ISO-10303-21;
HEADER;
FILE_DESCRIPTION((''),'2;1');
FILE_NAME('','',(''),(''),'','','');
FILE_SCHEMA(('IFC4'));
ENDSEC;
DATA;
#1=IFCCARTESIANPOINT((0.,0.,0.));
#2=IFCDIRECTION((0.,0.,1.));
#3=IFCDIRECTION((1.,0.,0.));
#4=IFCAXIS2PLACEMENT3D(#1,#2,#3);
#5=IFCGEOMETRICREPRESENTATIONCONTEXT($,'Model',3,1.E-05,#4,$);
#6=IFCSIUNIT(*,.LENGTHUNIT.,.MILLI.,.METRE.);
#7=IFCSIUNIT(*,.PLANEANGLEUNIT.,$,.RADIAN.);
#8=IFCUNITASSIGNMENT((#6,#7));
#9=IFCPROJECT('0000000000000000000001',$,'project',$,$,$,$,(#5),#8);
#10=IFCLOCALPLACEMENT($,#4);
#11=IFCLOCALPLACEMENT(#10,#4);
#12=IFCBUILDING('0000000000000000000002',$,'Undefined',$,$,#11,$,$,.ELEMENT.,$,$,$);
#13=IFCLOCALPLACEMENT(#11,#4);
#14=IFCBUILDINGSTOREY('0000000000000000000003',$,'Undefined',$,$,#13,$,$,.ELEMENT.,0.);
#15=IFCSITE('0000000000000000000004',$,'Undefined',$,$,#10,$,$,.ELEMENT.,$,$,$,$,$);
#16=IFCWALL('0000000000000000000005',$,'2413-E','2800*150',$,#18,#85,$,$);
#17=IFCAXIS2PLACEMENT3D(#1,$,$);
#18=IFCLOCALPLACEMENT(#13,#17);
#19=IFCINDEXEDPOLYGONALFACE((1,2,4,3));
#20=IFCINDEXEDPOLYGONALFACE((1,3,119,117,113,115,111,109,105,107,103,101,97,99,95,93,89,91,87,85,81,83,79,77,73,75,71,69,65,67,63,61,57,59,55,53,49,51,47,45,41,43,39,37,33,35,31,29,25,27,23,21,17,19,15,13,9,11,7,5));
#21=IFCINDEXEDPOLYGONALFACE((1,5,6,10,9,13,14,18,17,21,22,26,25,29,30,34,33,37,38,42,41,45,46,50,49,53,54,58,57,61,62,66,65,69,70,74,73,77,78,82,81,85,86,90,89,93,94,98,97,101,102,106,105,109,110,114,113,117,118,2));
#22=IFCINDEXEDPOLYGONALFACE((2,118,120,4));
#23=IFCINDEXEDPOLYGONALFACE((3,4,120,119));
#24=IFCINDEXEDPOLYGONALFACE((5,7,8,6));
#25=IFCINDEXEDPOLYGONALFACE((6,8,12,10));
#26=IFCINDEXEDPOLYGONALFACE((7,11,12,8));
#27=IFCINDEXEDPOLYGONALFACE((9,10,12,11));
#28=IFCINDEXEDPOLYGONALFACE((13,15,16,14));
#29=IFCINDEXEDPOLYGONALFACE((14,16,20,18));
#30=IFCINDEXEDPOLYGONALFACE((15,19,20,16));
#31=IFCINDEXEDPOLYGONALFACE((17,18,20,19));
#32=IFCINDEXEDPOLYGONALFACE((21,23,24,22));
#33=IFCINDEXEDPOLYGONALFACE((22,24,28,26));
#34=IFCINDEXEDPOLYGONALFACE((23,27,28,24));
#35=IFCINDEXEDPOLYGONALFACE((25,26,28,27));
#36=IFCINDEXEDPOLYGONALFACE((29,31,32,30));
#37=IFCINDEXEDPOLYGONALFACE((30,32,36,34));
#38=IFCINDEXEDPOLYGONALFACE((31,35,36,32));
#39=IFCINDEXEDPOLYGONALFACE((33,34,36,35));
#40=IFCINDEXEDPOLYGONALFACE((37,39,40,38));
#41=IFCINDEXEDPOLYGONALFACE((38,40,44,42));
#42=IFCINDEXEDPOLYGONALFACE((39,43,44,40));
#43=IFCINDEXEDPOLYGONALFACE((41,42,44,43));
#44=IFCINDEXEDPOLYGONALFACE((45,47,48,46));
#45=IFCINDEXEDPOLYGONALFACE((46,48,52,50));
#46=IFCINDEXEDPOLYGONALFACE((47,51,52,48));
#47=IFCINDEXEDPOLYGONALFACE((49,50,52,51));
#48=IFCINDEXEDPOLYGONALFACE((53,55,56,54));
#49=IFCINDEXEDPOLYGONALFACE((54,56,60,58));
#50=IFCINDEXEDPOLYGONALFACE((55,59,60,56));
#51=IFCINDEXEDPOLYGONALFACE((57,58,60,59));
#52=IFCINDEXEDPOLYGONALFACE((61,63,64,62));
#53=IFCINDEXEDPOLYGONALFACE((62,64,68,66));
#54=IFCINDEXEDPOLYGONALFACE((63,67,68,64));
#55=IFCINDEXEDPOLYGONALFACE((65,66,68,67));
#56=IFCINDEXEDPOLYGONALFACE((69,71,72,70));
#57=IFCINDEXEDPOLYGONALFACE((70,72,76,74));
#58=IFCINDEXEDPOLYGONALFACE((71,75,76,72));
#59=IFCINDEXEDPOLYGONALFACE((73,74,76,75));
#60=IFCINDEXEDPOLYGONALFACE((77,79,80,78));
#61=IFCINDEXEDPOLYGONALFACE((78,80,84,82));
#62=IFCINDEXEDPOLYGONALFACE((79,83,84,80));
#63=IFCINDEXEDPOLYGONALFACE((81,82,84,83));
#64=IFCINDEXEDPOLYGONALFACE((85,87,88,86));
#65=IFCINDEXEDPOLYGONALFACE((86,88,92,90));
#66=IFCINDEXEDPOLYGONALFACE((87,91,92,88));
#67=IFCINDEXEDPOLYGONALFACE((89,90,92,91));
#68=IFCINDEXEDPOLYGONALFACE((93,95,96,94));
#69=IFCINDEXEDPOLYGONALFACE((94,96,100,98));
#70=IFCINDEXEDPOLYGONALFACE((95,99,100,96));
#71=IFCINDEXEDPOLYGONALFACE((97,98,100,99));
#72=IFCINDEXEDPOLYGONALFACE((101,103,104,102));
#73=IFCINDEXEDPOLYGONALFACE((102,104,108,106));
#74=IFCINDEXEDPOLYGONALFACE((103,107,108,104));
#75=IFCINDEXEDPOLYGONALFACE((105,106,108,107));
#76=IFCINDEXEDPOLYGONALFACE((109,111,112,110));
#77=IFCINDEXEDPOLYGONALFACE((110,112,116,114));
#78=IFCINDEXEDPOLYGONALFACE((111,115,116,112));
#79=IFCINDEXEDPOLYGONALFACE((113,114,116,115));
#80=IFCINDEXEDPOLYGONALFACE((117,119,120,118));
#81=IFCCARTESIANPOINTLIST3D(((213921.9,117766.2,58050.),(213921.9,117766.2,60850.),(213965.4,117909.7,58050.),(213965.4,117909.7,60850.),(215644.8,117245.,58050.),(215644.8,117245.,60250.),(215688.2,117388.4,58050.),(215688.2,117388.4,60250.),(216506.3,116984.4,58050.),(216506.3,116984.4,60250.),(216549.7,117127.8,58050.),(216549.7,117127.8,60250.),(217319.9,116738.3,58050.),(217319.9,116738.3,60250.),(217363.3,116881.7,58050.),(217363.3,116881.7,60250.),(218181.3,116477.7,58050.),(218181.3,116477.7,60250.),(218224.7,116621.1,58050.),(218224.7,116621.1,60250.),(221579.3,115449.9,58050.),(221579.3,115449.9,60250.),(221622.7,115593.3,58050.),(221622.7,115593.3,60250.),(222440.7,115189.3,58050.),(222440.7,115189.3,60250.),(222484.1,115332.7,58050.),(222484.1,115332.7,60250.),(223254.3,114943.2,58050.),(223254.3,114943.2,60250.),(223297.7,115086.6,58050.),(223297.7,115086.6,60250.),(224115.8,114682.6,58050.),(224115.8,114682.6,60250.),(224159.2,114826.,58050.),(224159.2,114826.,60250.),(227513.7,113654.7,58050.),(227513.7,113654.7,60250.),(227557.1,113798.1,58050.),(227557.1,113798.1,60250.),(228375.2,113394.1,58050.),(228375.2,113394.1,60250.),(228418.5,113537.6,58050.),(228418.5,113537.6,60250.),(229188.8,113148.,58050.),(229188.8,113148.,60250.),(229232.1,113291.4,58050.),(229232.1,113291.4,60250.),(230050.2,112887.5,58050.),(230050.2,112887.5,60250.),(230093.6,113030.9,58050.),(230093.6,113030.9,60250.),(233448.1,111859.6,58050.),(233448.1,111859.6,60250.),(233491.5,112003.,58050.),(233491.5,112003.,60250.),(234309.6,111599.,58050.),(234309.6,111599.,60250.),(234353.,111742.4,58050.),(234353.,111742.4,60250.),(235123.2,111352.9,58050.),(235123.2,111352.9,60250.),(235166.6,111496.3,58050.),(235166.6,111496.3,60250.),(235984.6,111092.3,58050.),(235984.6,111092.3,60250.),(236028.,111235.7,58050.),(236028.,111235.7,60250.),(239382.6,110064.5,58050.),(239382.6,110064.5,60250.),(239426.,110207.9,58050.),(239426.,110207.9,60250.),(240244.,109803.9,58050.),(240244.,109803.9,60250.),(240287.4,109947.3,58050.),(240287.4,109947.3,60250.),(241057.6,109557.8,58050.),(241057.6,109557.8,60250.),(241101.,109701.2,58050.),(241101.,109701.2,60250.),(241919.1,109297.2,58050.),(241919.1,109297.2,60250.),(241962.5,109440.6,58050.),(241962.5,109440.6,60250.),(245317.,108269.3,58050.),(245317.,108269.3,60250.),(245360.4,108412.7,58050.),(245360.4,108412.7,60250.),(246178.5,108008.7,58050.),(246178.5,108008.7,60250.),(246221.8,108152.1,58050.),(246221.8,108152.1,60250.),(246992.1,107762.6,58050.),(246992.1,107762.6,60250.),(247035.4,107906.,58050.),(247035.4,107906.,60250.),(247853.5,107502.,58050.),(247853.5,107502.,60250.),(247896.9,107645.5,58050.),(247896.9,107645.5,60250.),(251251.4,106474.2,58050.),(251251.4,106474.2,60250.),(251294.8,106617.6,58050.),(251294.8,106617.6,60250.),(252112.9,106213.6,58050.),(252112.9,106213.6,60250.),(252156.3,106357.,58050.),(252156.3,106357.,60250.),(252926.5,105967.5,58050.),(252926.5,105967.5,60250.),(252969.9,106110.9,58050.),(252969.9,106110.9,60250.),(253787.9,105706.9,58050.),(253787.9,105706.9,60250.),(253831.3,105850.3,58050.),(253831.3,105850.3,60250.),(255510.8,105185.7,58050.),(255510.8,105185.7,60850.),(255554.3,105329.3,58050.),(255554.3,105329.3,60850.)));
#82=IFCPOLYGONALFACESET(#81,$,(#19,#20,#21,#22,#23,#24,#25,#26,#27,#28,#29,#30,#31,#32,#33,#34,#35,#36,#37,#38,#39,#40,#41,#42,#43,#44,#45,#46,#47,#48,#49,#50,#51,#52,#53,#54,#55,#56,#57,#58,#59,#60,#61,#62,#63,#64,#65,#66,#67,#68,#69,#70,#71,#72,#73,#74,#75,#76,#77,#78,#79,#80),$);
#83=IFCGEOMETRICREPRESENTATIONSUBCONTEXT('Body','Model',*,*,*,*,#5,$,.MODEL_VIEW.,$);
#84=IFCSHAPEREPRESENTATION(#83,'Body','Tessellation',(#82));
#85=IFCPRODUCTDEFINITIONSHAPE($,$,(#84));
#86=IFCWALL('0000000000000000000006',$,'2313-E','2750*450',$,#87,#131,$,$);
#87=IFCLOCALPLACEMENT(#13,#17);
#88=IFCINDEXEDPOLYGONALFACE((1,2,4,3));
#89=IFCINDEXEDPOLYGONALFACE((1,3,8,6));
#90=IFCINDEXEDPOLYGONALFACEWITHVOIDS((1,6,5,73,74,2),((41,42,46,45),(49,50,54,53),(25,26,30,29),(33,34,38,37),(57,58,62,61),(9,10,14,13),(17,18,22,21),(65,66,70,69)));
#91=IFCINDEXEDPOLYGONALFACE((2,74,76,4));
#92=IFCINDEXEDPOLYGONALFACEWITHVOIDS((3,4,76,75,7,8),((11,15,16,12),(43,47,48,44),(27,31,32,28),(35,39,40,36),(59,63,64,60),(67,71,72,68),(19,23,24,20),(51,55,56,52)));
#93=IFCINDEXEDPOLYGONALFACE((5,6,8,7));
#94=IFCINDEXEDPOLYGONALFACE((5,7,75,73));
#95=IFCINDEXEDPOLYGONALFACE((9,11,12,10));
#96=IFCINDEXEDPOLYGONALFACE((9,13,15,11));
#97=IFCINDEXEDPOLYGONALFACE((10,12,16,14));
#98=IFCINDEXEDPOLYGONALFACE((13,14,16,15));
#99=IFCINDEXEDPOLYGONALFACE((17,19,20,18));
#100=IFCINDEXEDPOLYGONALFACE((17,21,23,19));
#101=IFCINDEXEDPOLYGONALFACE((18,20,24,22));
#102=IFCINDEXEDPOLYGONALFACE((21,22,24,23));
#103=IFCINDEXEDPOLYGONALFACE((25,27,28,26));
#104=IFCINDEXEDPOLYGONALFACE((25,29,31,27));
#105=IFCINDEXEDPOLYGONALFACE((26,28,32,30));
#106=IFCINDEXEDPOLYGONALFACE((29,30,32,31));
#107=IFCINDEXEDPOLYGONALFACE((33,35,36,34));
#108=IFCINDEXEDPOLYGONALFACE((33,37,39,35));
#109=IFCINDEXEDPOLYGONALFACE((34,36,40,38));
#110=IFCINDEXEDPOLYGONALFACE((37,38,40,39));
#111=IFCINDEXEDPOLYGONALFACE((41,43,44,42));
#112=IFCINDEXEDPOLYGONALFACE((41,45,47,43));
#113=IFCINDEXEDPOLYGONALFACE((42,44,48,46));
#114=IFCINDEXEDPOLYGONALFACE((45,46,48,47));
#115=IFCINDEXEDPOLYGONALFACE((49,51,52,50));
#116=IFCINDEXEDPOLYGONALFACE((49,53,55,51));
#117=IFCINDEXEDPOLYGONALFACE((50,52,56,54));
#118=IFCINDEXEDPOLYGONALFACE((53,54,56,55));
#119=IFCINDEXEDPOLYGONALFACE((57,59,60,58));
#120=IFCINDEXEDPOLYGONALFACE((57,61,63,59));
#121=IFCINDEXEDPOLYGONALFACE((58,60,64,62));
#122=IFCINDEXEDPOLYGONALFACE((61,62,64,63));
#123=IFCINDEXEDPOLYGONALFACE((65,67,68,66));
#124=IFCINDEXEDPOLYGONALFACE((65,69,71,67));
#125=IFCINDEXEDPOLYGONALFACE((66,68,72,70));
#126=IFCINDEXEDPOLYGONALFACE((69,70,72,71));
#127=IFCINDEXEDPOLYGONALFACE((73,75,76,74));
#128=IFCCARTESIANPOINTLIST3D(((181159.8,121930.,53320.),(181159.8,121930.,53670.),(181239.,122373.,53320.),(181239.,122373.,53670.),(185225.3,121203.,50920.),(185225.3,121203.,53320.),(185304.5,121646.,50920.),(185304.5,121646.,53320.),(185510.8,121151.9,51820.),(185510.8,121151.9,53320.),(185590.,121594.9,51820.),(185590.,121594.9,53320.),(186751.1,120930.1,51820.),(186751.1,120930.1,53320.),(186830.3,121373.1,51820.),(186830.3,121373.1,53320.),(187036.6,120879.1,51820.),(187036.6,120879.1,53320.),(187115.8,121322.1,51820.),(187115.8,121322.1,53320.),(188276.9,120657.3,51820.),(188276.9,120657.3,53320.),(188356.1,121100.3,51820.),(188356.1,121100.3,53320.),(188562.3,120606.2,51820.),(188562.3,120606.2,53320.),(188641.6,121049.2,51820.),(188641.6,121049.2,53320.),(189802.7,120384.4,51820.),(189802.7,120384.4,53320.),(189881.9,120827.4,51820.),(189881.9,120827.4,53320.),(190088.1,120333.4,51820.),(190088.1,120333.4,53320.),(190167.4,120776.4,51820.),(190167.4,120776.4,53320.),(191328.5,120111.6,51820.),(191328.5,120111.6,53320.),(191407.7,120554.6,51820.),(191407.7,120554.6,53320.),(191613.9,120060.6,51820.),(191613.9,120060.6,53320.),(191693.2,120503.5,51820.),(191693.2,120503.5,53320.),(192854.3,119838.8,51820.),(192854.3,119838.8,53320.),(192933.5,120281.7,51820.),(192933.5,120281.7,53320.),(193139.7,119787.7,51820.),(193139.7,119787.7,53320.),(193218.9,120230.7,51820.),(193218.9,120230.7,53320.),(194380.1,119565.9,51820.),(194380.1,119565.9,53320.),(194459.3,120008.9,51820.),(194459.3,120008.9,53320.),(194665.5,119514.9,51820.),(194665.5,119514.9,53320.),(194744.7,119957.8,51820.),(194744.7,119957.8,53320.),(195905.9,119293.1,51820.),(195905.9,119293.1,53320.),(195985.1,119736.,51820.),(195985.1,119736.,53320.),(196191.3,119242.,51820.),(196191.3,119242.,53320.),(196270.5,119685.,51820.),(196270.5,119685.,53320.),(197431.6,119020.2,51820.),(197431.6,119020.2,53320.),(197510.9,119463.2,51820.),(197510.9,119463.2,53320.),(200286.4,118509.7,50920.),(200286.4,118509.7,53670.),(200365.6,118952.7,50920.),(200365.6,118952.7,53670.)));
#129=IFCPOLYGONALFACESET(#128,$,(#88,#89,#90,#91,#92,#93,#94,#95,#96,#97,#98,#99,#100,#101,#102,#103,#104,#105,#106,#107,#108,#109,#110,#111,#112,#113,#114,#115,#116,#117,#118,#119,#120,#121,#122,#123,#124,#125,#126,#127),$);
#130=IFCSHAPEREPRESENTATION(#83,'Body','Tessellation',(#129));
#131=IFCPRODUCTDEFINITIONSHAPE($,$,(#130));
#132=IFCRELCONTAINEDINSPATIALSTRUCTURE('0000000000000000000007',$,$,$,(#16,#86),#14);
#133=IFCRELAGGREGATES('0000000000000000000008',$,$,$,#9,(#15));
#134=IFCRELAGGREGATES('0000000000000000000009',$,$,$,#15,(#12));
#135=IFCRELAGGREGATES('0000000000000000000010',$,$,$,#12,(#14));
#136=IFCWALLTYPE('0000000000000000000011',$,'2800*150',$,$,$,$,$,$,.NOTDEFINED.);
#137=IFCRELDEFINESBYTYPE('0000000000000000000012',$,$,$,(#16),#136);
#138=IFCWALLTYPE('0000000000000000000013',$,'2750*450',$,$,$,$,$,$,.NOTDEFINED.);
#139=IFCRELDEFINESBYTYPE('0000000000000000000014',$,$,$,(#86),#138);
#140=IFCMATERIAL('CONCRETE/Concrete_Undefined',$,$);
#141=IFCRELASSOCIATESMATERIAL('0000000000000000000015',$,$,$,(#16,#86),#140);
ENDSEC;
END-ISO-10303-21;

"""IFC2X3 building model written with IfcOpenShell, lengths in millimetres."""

from ifc_helpers import new_model, si_unit, frame, frame_2d, origin_with_axes, place, context, subcontext, project, spatial, rectangle, extrude, boolean, material, type_object, element, save


model = new_model("IFC2X3")

# Units and contexts
model_context = context("Model", 3, precision=1e-05, world=origin_with_axes())
body_context = subcontext(model_context, "Body", "Model", "MODEL_VIEW")
ifc_project = project(units=[si_unit("LENGTHUNIT", "METRE", prefix="MILLI"), si_unit("PLANEANGLEUNIT", "RADIAN")], contexts=[model_context])

# Site, building, storey
site_placement = place(None, origin_with_axes())
site = spatial("IfcSite", under=ifc_project, at=site_placement, Name="Undefined", CompositionType="ELEMENT")
building_placement = place(site_placement, origin_with_axes())
building = spatial("IfcBuilding", under=site, at=building_placement, Name="Undefined", CompositionType="ELEMENT")
storey_placement = place(building_placement, origin_with_axes())
storey = spatial("IfcBuildingStorey", under=building, at=storey_placement, Name="Undefined", CompositionType="ELEMENT", Elevation=0.0)

# Shared definitions
ifc_material_1 = material(Name="CONCRETE/Concrete_Undefined")

# Walls
wall_type_1 = type_object("IfcWallType", Name="2800*150", PredefinedType="NOTDEFINED")
wall_1_placement = place(storey_placement, frame((213943.7, 117838.0, 58050.0), z_axis=(0.0, 0.0, 1.0), x_axis=(0.957167, -0.289538, 0.0)))
solid_1 = boolean("DIFFERENCE", boolean("DIFFERENCE", boolean("DIFFERENCE", boolean("DIFFERENCE", boolean("DIFFERENCE", boolean("DIFFERENCE", boolean("DIFFERENCE", boolean("DIFFERENCE", extrude(rectangle(XDim=43450.0, YDim=150.0, at=frame_2d((0.0, 21725.0), x_axis=(0.0, -1.0))), frame((0.0, 0.0, 0.0), z_axis=(0.0, 0.0, 1.0), x_axis=(0.0, -1.0, 0.0)), (0.0, 0.0, 1.0), 2800.0), extrude(rectangle(XDim=900.0, YDim=150.0, at=frame_2d((0.0, 450.0), x_axis=(0.0, -1.0))), frame((39000.0, -0.2, 0.0), z_axis=(0.0, 0.0, 1.0), x_axis=(-0.000003, -1.0, 0.0)), (0.0, 0.0, 1.0), 2200.0)), extrude(rectangle(XDim=900.0, YDim=150.0, at=frame_2d((0.0, 450.0), x_axis=(0.0, -1.0))), frame((40750.0, -0.2, 0.0), z_axis=(0.0, 0.0, 1.0), x_axis=(-0.000003, -1.0, 0.0)), (0.0, 0.0, 1.0), 2200.0)), extrude(rectangle(XDim=900.0, YDim=150.0, at=frame_2d((0.0, 450.0), x_axis=(0.0, -1.0))), frame((32800.0, -0.2, 0.0), z_axis=(0.0, 0.0, 1.0), x_axis=(-0.000003, -1.0, 0.0)), (0.0, 0.0, 1.0), 2200.0)), extrude(rectangle(XDim=900.0, YDim=150.0, at=frame_2d((0.0, 450.0), x_axis=(0.0, -1.0))), frame((34550.0, -0.2, 0.0), z_axis=(0.0, 0.0, 1.0), x_axis=(-0.000003, -1.0, 0.0)), (0.0, 0.0, 1.0), 2200.0)), extrude(rectangle(XDim=900.0, YDim=150.0, at=frame_2d((0.0, 450.0), x_axis=(0.0, -1.0))), frame((26600.0, -0.2, 0.0), z_axis=(0.0, 0.0, 1.0), x_axis=(-0.000003, -1.0, 0.0)), (0.0, 0.0, 1.0), 2200.0)), extrude(rectangle(XDim=900.0, YDim=150.0, at=frame_2d((0.0, 450.0), x_axis=(0.0, -1.0))), frame((28350.0, -0.2, 0.0), z_axis=(0.0, 0.0, 1.0), x_axis=(-0.000003, -1.0, 0.0)), (0.0, 0.0, 1.0), 2200.0)), extrude(rectangle(XDim=900.0, YDim=150.0, at=frame_2d((0.0, 450.0), x_axis=(0.0, -1.0))), frame((20400.0, -0.2, 0.0), z_axis=(0.0, 0.0, 1.0), x_axis=(-0.000003, -1.0, 0.0)), (0.0, 0.0, 1.0), 2200.0)), extrude(rectangle(XDim=900.0, YDim=150.0, at=frame_2d((0.0, 450.0), x_axis=(0.0, -1.0))), frame((22150.0, -0.2, 0.0), z_axis=(0.0, 0.0, 1.0), x_axis=(-0.000003, -1.0, 0.0)), (0.0, 0.0, 1.0), 2200.0))
element("IfcWall", 1, at=wall_1_placement, inside=storey, type_object=wall_type_1, material=ifc_material_1, Name="2413-E", Description="2800*150", context=body_context, shape_type="CSG", body=[
    boolean("DIFFERENCE", boolean("DIFFERENCE", boolean("DIFFERENCE", boolean("DIFFERENCE", boolean("DIFFERENCE", boolean("DIFFERENCE", solid_1, extrude(rectangle(XDim=900.0, YDim=150.0, at=frame_2d((0.0, 450.0), x_axis=(0.0, -1.0))), frame((14200.0, -0.2, 0.0), z_axis=(0.0, 0.0, 1.0), x_axis=(-0.000003, -1.0, 0.0)), (0.0, 0.0, 1.0), 2200.0)), extrude(rectangle(XDim=900.0, YDim=150.0, at=frame_2d((0.0, 450.0), x_axis=(0.0, -1.0))), frame((15950.0, -0.2, 0.0), z_axis=(0.0, 0.0, 1.0), x_axis=(-0.000003, -1.0, 0.0)), (0.0, 0.0, 1.0), 2200.0)), extrude(rectangle(XDim=900.0, YDim=150.0, at=frame_2d((0.0, 450.0), x_axis=(0.0, -1.0))), frame((8000.0, -0.2, 0.0), z_axis=(0.0, 0.0, 1.0), x_axis=(-0.000003, -1.0, 0.0)), (0.0, 0.0, 1.0), 2200.0)), extrude(rectangle(XDim=900.0, YDim=150.0, at=frame_2d((0.0, 450.0), x_axis=(0.0, -1.0))), frame((9750.0, -0.2, 0.0), z_axis=(0.0, 0.0, 1.0), x_axis=(-0.000003, -1.0, 0.0)), (0.0, 0.0, 1.0), 2200.0)), extrude(rectangle(XDim=900.0, YDim=150.0, at=frame_2d((0.0, 450.0), x_axis=(0.0, -1.0))), frame((1800.0, -0.2, 0.0), z_axis=(0.0, 0.0, 1.0), x_axis=(-0.000003, -1.0, 0.0)), (0.0, 0.0, 1.0), 2200.0)), extrude(rectangle(XDim=900.0, YDim=150.0, at=frame_2d((0.0, 450.0), x_axis=(0.0, -1.0))), frame((3550.0, -0.2, 0.0), z_axis=(0.0, 0.0, 1.0), x_axis=(-0.000003, -1.0, 0.0)), (0.0, 0.0, 1.0), 2200.0)),
])
wall_type_2 = type_object("IfcWallType", Name="2750*450", PredefinedType="NOTDEFINED")
wall_2_placement = place(storey_placement, frame((200326.0, 118731.2, 50920.0), z_axis=(0.0, 0.0, 1.0), x_axis=(-0.984385, 0.176032, 0.0)))
solid_2 = boolean("DIFFERENCE", boolean("DIFFERENCE", boolean("DIFFERENCE", boolean("DIFFERENCE", boolean("DIFFERENCE", boolean("DIFFERENCE", boolean("DIFFERENCE", boolean("DIFFERENCE", extrude(rectangle(XDim=19430.0, YDim=450.0, at=frame_2d((0.0, 9715.0), x_axis=(0.0, -1.0))), frame((0.0, 0.0, 0.0), z_axis=(0.0, 0.0, 1.0), x_axis=(0.0, -1.0, 0.0)), (0.0, 0.0, 1.0), 2750.0), extrude(rectangle(XDim=4130.0, YDim=450.0, at=frame_2d((0.0, 2065.0), x_axis=(0.0, -1.0))), frame((19430.0, 0.0, 0.0), z_axis=(0.0, 0.0, 1.0), x_axis=(0.0, 1.0, 0.0)), (0.0, 0.0, 1.0), 2400.0)), extrude(rectangle(XDim=1260.0, YDim=450.0, at=frame_2d((0.0, 630.0), x_axis=(0.0, -1.0))), frame((4160.0, 0.0, 900.0), z_axis=(0.0, 0.0, 1.0), x_axis=(0.0, 1.0, 0.0)), (0.0, 0.0, 1.0), 1500.0)), extrude(rectangle(XDim=1260.0, YDim=450.0, at=frame_2d((0.0, 630.0), x_axis=(0.0, -1.0))), frame((5710.0, 0.0, 900.0), z_axis=(0.0, 0.0, 1.0), x_axis=(0.0, 1.0, 0.0)), (0.0, 0.0, 1.0), 1500.0)), extrude(rectangle(XDim=1260.0, YDim=450.0, at=frame_2d((0.0, 630.0), x_axis=(0.0, -1.0))), frame((7260.0, 0.0, 900.0), z_axis=(0.0, 0.0, 1.0), x_axis=(0.0, 1.0, 0.0)), (0.0, 0.0, 1.0), 1500.0)), extrude(rectangle(XDim=1260.0, YDim=450.0, at=frame_2d((0.0, 630.0), x_axis=(0.0, -1.0))), frame((8810.0, 0.0, 900.0), z_axis=(0.0, 0.0, 1.0), x_axis=(0.0, 1.0, 0.0)), (0.0, 0.0, 1.0), 1500.0)), extrude(rectangle(XDim=1260.0, YDim=450.0, at=frame_2d((0.0, 630.0), x_axis=(0.0, -1.0))), frame((10360.0, 0.0, 900.0), z_axis=(0.0, 0.0, 1.0), x_axis=(0.0, 1.0, 0.0)), (0.0, 0.0, 1.0), 1500.0)), extrude(rectangle(XDim=1260.0, YDim=450.0, at=frame_2d((0.0, 630.0), x_axis=(0.0, -1.0))), frame((11910.0, 0.0, 900.0), z_axis=(0.0, 0.0, 1.0), x_axis=(0.0, 1.0, 0.0)), (0.0, 0.0, 1.0), 1500.0)), extrude(rectangle(XDim=1260.0, YDim=450.0, at=frame_2d((0.0, 630.0), x_axis=(0.0, -1.0))), frame((13460.0, 0.0, 900.0), z_axis=(0.0, 0.0, 1.0), x_axis=(0.0, 1.0, 0.0)), (0.0, 0.0, 1.0), 1500.0))
element("IfcWall", 2, at=wall_2_placement, inside=storey, type_object=wall_type_2, material=ifc_material_1, Name="2313-E", Description="2750*450", context=body_context, shape_type="CSG", body=[
    boolean("DIFFERENCE", solid_2, extrude(rectangle(XDim=1260.0, YDim=450.0, at=frame_2d((0.0, 630.0), x_axis=(0.0, -1.0))), frame((15010.0, 0.0, 900.0), z_axis=(0.0, 0.0, 1.0), x_axis=(0.0, 1.0, 0.0)), (0.0, 0.0, 1.0), 1500.0)),
])

save(model, "model.ifc")
